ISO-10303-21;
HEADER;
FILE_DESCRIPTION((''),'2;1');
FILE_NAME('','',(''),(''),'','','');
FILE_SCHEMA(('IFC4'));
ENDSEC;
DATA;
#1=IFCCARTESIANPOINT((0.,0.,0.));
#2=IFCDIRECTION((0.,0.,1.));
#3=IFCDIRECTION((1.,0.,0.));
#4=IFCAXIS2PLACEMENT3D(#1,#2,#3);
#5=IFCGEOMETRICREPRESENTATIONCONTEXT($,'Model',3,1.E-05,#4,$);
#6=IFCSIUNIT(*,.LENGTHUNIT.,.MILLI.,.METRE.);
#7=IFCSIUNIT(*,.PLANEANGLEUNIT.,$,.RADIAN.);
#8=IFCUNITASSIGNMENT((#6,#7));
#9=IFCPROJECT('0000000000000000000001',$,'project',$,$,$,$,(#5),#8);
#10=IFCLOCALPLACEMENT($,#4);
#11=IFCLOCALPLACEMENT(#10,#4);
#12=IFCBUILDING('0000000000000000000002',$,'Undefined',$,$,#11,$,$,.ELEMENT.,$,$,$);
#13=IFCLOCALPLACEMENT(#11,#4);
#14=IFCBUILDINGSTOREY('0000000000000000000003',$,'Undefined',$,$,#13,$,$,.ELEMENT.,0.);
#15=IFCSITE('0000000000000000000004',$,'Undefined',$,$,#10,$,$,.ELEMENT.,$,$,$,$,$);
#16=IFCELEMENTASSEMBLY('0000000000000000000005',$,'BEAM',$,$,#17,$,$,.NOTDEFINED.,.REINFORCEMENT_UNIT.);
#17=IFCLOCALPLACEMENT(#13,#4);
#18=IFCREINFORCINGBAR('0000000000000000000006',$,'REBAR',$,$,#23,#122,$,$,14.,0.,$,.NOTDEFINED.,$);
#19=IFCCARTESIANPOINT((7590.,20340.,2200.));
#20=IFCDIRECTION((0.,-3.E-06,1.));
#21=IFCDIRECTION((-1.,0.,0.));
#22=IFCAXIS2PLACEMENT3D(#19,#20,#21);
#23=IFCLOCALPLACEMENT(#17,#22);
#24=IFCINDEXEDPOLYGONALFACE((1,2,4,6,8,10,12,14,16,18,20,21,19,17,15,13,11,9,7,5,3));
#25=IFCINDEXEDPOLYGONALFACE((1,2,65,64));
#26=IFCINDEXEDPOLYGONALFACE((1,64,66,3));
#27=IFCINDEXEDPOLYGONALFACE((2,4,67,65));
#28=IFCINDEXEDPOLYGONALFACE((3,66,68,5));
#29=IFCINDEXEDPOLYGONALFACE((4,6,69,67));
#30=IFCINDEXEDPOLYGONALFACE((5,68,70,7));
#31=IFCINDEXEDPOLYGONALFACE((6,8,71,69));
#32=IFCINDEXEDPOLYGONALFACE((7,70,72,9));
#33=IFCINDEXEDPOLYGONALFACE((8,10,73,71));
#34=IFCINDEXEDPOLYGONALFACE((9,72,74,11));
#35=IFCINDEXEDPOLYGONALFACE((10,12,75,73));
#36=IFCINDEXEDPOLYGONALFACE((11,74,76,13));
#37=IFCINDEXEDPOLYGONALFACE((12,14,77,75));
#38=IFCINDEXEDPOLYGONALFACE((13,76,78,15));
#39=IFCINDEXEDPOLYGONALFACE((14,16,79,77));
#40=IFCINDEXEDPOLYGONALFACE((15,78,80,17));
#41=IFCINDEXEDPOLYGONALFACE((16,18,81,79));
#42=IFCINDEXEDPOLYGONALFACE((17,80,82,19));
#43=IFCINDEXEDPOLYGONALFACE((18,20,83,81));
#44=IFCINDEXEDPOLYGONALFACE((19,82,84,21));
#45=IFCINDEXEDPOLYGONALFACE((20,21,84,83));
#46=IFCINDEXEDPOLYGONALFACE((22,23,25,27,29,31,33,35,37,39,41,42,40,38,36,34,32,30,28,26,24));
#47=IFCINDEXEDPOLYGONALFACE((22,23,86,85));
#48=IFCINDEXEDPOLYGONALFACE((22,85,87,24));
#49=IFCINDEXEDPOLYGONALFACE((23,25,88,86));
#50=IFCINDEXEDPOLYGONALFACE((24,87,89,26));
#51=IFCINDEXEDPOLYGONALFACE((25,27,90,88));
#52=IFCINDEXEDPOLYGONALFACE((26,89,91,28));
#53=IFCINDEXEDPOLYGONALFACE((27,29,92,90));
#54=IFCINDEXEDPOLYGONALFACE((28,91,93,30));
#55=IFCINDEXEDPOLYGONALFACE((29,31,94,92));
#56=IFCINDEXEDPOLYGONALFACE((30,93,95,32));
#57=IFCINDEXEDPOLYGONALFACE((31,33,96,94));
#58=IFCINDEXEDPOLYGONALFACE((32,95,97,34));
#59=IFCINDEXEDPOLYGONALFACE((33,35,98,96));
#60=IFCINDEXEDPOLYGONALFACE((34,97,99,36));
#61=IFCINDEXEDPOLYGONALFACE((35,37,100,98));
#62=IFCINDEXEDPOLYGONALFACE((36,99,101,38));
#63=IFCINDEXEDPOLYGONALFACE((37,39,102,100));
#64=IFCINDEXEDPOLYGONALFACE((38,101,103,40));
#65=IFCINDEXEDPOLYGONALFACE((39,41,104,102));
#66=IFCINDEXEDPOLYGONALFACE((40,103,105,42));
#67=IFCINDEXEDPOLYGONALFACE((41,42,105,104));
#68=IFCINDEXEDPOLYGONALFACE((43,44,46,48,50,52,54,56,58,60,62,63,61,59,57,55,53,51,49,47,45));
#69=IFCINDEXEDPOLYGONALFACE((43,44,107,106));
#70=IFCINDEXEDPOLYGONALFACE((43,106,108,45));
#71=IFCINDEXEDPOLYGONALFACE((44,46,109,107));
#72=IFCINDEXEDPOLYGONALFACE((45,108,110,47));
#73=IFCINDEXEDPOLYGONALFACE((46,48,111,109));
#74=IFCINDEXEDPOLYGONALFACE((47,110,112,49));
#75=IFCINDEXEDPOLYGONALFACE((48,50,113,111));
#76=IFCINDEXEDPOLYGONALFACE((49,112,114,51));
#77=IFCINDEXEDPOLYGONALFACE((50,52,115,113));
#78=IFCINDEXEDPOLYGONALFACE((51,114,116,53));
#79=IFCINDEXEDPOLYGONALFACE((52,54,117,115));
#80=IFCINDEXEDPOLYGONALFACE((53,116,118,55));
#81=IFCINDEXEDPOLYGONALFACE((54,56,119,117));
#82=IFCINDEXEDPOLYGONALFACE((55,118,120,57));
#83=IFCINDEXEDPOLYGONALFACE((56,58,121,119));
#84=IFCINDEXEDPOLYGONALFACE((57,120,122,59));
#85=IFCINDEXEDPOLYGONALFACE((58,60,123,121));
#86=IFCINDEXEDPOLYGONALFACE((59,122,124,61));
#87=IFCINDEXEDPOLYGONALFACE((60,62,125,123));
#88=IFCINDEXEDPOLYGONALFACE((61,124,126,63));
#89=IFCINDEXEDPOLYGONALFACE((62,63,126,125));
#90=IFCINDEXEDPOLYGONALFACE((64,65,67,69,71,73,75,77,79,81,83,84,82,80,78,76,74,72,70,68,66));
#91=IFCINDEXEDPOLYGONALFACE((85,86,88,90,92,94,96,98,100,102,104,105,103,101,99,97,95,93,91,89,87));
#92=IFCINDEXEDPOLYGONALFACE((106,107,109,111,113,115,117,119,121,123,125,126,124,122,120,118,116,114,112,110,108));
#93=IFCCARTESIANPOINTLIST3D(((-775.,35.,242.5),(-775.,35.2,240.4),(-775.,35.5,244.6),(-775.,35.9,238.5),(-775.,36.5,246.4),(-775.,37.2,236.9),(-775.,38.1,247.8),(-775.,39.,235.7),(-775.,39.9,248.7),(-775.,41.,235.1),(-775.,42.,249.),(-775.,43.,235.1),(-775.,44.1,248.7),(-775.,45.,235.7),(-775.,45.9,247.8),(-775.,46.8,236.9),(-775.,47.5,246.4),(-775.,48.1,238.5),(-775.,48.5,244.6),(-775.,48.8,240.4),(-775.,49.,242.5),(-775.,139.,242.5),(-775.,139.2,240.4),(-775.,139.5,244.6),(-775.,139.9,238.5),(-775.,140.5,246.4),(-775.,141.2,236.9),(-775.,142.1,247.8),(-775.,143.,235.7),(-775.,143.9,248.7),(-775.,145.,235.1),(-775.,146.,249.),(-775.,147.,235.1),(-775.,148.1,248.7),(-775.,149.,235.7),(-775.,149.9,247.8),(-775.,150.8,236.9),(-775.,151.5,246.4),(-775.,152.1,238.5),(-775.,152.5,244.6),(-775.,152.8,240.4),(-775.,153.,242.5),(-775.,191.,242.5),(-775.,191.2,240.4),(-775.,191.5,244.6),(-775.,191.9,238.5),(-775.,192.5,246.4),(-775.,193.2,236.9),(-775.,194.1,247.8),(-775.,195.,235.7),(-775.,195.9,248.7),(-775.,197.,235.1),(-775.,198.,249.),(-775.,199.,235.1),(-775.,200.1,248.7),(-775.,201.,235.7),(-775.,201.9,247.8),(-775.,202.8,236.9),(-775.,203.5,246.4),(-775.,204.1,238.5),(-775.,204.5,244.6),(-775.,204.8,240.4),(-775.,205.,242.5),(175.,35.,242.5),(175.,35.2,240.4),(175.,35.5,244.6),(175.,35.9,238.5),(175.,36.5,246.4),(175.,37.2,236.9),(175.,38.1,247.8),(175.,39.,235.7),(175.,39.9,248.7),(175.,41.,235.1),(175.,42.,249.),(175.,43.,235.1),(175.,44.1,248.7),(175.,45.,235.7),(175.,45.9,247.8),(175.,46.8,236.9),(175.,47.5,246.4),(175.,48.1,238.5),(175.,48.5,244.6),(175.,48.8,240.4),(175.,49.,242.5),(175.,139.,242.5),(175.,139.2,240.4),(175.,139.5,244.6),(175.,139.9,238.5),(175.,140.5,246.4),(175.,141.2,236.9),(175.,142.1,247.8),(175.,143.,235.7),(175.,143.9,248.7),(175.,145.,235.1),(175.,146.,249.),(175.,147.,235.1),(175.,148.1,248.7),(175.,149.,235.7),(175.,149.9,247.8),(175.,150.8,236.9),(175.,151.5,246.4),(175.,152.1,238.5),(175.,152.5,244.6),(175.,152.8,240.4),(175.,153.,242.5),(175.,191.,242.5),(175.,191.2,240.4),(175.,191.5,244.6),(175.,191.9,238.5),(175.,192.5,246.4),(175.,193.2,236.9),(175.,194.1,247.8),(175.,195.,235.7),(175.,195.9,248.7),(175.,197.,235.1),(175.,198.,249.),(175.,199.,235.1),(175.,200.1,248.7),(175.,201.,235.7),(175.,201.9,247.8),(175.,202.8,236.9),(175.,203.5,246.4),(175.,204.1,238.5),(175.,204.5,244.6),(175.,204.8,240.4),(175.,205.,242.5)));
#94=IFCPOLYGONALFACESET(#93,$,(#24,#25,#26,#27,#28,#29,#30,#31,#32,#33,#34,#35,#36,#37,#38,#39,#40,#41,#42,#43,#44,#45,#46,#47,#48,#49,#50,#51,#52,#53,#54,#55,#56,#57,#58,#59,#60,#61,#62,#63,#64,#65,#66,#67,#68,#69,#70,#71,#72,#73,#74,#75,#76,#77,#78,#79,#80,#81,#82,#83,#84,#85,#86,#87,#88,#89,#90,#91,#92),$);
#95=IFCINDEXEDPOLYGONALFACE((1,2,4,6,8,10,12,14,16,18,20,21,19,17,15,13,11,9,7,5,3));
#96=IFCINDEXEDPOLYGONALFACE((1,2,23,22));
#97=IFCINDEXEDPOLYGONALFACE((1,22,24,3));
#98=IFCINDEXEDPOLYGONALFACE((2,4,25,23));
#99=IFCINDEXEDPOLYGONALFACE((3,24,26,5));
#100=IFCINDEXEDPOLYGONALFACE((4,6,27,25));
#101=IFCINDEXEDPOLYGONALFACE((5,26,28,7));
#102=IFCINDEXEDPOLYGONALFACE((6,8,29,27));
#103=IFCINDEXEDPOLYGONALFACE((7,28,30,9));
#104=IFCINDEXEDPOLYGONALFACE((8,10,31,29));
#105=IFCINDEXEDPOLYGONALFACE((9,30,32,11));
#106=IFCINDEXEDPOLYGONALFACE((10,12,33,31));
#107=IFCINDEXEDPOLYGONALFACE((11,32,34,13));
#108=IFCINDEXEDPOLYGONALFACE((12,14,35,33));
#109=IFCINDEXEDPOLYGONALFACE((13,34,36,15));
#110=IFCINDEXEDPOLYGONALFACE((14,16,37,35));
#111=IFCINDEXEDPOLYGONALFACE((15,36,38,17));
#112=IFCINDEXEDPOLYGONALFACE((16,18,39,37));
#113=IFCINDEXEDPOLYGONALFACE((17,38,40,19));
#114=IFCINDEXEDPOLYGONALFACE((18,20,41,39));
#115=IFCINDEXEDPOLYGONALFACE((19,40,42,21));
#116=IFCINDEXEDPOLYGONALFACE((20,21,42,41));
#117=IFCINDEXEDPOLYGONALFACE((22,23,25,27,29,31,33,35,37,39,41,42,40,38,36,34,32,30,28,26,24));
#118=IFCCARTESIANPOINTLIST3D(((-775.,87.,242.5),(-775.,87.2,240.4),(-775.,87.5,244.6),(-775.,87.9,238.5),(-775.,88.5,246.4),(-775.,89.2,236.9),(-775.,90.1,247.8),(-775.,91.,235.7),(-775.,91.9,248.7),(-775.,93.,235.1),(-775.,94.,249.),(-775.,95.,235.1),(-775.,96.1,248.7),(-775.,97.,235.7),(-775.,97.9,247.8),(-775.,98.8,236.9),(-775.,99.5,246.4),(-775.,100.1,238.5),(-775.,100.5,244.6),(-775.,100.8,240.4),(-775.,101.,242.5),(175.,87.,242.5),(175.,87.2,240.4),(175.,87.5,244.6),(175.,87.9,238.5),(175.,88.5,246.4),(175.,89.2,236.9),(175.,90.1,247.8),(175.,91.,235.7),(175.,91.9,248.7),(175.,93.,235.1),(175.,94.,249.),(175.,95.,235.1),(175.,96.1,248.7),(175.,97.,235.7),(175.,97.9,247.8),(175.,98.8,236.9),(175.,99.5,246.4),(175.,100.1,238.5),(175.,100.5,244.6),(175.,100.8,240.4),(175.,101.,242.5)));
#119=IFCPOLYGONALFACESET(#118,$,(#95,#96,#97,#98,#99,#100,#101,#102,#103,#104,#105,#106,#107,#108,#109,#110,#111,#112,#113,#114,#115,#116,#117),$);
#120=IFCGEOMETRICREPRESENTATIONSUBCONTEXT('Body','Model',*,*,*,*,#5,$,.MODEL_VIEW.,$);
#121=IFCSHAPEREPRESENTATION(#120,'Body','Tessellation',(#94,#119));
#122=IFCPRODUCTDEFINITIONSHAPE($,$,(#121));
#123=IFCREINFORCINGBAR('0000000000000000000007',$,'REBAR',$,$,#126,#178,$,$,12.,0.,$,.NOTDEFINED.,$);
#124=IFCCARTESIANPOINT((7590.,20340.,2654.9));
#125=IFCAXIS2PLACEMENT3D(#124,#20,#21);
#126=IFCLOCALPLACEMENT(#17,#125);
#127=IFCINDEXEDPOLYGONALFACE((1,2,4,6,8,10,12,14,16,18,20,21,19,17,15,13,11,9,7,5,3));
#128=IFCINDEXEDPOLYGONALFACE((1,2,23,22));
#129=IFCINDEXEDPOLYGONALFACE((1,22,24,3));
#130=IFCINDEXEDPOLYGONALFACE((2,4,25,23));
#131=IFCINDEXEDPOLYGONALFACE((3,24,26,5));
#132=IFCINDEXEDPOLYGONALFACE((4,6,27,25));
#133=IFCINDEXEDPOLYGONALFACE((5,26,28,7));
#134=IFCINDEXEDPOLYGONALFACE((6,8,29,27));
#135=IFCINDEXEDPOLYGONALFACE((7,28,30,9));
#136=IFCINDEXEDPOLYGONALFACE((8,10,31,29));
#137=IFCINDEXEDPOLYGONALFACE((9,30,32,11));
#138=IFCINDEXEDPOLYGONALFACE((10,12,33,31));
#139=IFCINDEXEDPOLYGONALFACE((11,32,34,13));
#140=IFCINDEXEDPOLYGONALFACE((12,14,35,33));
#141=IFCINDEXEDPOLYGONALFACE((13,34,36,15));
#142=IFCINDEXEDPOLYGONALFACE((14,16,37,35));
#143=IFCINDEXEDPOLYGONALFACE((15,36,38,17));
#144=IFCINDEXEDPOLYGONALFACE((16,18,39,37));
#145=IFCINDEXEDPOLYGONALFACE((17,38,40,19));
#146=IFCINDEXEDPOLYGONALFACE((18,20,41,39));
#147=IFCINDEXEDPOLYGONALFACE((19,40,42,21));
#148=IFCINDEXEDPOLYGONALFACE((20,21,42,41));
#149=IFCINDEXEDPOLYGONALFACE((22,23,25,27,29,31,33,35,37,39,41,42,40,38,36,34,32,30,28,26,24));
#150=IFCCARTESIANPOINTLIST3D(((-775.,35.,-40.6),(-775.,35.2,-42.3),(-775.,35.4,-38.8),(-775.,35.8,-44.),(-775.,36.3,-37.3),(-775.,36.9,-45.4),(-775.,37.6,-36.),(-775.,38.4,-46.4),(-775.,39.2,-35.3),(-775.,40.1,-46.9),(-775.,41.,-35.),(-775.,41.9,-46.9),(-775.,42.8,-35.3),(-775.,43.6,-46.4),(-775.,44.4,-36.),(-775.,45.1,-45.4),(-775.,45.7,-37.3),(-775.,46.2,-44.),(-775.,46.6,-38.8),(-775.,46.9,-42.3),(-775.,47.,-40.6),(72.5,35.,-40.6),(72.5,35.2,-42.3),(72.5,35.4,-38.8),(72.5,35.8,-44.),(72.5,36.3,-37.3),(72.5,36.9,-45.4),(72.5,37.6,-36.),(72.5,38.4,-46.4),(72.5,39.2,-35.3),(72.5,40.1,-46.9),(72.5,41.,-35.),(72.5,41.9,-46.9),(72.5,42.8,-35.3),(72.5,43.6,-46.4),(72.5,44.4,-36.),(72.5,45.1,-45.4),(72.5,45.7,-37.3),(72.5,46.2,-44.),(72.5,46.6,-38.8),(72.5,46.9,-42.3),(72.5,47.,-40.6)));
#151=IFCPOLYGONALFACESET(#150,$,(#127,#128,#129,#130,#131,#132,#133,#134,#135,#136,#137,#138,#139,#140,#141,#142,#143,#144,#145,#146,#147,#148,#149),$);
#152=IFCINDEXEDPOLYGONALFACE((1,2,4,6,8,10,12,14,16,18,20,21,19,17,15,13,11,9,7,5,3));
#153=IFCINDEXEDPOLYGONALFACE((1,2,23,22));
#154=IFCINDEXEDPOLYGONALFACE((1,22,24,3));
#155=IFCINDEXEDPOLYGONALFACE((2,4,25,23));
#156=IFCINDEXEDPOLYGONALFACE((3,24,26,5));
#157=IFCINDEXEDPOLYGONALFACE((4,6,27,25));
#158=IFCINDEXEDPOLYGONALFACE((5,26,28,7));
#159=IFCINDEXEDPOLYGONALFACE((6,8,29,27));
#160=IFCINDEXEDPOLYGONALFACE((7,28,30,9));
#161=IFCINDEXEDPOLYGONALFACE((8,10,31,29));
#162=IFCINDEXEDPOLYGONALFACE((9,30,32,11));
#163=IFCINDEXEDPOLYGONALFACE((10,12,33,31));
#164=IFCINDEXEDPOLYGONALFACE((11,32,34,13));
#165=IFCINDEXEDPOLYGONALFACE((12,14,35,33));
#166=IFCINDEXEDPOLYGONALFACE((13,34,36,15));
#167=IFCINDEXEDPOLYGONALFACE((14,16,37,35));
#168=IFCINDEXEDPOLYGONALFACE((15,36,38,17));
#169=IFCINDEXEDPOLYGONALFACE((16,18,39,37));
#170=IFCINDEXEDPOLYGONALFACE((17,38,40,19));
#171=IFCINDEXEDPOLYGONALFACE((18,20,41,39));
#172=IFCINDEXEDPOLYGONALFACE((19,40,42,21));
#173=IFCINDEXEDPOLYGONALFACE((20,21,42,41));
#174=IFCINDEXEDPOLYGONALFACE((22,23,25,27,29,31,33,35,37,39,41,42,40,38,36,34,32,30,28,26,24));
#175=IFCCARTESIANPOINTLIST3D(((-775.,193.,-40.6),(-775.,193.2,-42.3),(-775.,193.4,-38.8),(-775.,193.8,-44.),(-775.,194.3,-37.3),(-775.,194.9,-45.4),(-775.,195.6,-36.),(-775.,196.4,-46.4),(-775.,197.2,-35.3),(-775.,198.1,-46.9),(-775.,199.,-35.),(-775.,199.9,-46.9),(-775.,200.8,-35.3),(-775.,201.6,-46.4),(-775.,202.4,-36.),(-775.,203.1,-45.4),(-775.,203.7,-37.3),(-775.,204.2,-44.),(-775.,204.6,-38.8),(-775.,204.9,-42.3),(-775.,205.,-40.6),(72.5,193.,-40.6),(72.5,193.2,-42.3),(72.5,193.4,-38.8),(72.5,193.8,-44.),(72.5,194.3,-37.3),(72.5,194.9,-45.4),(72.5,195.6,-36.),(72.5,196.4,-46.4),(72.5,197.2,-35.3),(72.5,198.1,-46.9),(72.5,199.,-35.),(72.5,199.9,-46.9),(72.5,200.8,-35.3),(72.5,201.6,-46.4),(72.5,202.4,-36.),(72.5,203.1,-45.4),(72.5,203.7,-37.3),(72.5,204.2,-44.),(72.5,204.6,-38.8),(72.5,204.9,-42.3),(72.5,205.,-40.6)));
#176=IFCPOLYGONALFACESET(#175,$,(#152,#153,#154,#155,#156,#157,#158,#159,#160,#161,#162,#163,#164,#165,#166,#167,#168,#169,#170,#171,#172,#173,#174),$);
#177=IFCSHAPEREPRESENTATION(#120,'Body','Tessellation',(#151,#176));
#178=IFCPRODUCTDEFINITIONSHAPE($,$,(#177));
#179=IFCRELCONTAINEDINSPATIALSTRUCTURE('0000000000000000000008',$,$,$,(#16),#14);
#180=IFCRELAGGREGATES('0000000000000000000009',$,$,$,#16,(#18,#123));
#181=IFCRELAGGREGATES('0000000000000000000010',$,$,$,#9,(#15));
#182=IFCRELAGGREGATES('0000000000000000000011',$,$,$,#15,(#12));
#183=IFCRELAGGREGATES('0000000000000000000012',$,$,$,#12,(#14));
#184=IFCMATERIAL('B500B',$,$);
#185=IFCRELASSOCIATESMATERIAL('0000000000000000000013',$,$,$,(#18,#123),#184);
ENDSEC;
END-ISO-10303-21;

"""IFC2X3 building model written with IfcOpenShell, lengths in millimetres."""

from ifc_helpers import new_model, entity, si_unit, frame, origin_with_axes, place, context, subcontext, project, spatial, source, transform, mapped, material, element, aggregate, save


model = new_model("IFC2X3")

# Units and contexts
model_context = context("Model", 3, precision=1e-05, world=origin_with_axes())
body_context = subcontext(model_context, "Body", "Model", "MODEL_VIEW")
ifc_project = project(units=[si_unit("LENGTHUNIT", "METRE", prefix="MILLI"), si_unit("PLANEANGLEUNIT", "RADIAN")], contexts=[model_context])

# Site, building, storey
site_placement = place(None, origin_with_axes())
site = spatial("IfcSite", under=ifc_project, at=site_placement, Name="Undefined", CompositionType="ELEMENT")
building_placement = place(site_placement, origin_with_axes())
building = spatial("IfcBuilding", under=site, at=building_placement, Name="Undefined", CompositionType="ELEMENT")
storey_placement = place(building_placement, origin_with_axes())
storey = spatial("IfcBuildingStorey", under=building, at=storey_placement, Name="Undefined", CompositionType="ELEMENT", Elevation=0.0)

# Element assembly
assembly_1_placement = place(storey_placement, origin_with_axes())
assembly_1 = element("IfcElementAssembly", 1, at=assembly_1_placement, inside=storey, Name="BEAM", AssemblyPlace="NOTDEFINED", PredefinedType="REINFORCEMENT_UNIT")

# Shared definitions
ifc_material_1 = material(Name="B500B")

# Reinforcing bars
shared_shape_1 = source(origin_with_axes(), body_context, "Body", "AdvancedSweptSolid", [
    entity("IfcSweptDiskSolid", entity("IfcTrimmedCurve", entity("IfcLine", entity("IfcCartesianPoint", [0.0, 0.0, 0.0]), entity("IfcVector", entity("IfcDirection", [1.0, 0.0, 0.0]), 1.0)), [entity("IfcParameterValue", 0.0)], [entity("IfcParameterValue", 949.999047)], True, "PARAMETER"), 7.0, None, 0.0, 950.0),
])
shared_shape_2 = source(origin_with_axes(), body_context, "Body", "AdvancedSweptSolid", [
    entity("IfcSweptDiskSolid", entity("IfcTrimmedCurve", entity("IfcLine", entity("IfcCartesianPoint", [0.0, 0.0, 0.0]), entity("IfcVector", entity("IfcDirection", [1.0, 0.0, 0.0]), 1.0)), [entity("IfcParameterValue", 0.0)], [entity("IfcParameterValue", 949.999047)], True, "PARAMETER"), 7.0, None, 0.0, 950.0),
])
shared_shape_3 = source(origin_with_axes(), body_context, "Body", "AdvancedSweptSolid", [
    entity("IfcSweptDiskSolid", entity("IfcTrimmedCurve", entity("IfcLine", entity("IfcCartesianPoint", [0.0, 0.0, 0.0]), entity("IfcVector", entity("IfcDirection", [1.0, 0.0, 0.0]), 1.0)), [entity("IfcParameterValue", 0.0)], [entity("IfcParameterValue", 949.999047)], True, "PARAMETER"), 7.0, None, 0.0, 950.0),
])
shared_shape_4 = source(origin_with_axes(), body_context, "Body", "AdvancedSweptSolid", [
    entity("IfcSweptDiskSolid", entity("IfcTrimmedCurve", entity("IfcLine", entity("IfcCartesianPoint", [0.0, 0.0, 0.0]), entity("IfcVector", entity("IfcDirection", [1.0, 0.0, 0.0]), 1.0)), [entity("IfcParameterValue", 0.0)], [entity("IfcParameterValue", 949.999047)], True, "PARAMETER"), 7.0, None, 0.0, 950.0),
])
reinforcing_bar_1_placement = place(assembly_1_placement, frame((7590.0, 20340.0, 2200.0), z_axis=(0.0, -0.000003, 1.0), x_axis=(-1.0, 0.0, 0.0)))
reinforcing_bar_1 = element("IfcReinforcingBar", 2, at=reinforcing_bar_1_placement, material=ifc_material_1, Name="REBAR", BarRole="NOTDEFINED", CrossSectionArea=0.0, NominalDiameter=14.0, context=body_context, shape_type="MappedRepresentation", body=[
    mapped(shared_shape_1, transform((-775.0, 42.0, 242.0))),
    mapped(shared_shape_2, transform((-775.0, 94.0, 242.0))),
    mapped(shared_shape_3, transform((-775.0, 146.0, 242.0))),
    mapped(shared_shape_4, transform((-775.0, 198.0, 242.0))),
])
shared_shape_5 = source(origin_with_axes(), body_context, "Body", "AdvancedSweptSolid", [
    entity("IfcSweptDiskSolid", entity("IfcTrimmedCurve", entity("IfcLine", entity("IfcCartesianPoint", [0.0, 0.0, 0.0]), entity("IfcVector", entity("IfcDirection", [1.0, 0.0, 0.0]), 1.0)), [entity("IfcParameterValue", 0.0)], [entity("IfcParameterValue", 847.459613)], True, "PARAMETER"), 6.0, None, 0.0, 847.5),
])
shared_shape_6 = source(origin_with_axes(), body_context, "Body", "AdvancedSweptSolid", [
    entity("IfcSweptDiskSolid", entity("IfcTrimmedCurve", entity("IfcLine", entity("IfcCartesianPoint", [0.0, 0.0, 0.0]), entity("IfcVector", entity("IfcDirection", [1.0, 0.0, 0.0]), 1.0)), [entity("IfcParameterValue", 0.0)], [entity("IfcParameterValue", 847.459613)], True, "PARAMETER"), 6.0, None, 0.0, 847.5),
])
reinforcing_bar_2_placement = place(assembly_1_placement, frame((7590.0, 20340.0, 2654.9), z_axis=(0.0, -0.000003, 1.0), x_axis=(-1.0, 0.0, 0.0)))
reinforcing_bar_2 = element("IfcReinforcingBar", 3, at=reinforcing_bar_2_placement, material=ifc_material_1, Name="REBAR", BarRole="NOTDEFINED", CrossSectionArea=0.0, NominalDiameter=12.0, context=body_context, shape_type="MappedRepresentation", body=[
    mapped(shared_shape_5, transform((-775.0, 41.0, -41.0))),
    mapped(shared_shape_6, transform((-775.0, 199.0, -41.0))),
])
aggregate(assembly_1, [reinforcing_bar_1, reinforcing_bar_2])

save(model, "model.ifc")
